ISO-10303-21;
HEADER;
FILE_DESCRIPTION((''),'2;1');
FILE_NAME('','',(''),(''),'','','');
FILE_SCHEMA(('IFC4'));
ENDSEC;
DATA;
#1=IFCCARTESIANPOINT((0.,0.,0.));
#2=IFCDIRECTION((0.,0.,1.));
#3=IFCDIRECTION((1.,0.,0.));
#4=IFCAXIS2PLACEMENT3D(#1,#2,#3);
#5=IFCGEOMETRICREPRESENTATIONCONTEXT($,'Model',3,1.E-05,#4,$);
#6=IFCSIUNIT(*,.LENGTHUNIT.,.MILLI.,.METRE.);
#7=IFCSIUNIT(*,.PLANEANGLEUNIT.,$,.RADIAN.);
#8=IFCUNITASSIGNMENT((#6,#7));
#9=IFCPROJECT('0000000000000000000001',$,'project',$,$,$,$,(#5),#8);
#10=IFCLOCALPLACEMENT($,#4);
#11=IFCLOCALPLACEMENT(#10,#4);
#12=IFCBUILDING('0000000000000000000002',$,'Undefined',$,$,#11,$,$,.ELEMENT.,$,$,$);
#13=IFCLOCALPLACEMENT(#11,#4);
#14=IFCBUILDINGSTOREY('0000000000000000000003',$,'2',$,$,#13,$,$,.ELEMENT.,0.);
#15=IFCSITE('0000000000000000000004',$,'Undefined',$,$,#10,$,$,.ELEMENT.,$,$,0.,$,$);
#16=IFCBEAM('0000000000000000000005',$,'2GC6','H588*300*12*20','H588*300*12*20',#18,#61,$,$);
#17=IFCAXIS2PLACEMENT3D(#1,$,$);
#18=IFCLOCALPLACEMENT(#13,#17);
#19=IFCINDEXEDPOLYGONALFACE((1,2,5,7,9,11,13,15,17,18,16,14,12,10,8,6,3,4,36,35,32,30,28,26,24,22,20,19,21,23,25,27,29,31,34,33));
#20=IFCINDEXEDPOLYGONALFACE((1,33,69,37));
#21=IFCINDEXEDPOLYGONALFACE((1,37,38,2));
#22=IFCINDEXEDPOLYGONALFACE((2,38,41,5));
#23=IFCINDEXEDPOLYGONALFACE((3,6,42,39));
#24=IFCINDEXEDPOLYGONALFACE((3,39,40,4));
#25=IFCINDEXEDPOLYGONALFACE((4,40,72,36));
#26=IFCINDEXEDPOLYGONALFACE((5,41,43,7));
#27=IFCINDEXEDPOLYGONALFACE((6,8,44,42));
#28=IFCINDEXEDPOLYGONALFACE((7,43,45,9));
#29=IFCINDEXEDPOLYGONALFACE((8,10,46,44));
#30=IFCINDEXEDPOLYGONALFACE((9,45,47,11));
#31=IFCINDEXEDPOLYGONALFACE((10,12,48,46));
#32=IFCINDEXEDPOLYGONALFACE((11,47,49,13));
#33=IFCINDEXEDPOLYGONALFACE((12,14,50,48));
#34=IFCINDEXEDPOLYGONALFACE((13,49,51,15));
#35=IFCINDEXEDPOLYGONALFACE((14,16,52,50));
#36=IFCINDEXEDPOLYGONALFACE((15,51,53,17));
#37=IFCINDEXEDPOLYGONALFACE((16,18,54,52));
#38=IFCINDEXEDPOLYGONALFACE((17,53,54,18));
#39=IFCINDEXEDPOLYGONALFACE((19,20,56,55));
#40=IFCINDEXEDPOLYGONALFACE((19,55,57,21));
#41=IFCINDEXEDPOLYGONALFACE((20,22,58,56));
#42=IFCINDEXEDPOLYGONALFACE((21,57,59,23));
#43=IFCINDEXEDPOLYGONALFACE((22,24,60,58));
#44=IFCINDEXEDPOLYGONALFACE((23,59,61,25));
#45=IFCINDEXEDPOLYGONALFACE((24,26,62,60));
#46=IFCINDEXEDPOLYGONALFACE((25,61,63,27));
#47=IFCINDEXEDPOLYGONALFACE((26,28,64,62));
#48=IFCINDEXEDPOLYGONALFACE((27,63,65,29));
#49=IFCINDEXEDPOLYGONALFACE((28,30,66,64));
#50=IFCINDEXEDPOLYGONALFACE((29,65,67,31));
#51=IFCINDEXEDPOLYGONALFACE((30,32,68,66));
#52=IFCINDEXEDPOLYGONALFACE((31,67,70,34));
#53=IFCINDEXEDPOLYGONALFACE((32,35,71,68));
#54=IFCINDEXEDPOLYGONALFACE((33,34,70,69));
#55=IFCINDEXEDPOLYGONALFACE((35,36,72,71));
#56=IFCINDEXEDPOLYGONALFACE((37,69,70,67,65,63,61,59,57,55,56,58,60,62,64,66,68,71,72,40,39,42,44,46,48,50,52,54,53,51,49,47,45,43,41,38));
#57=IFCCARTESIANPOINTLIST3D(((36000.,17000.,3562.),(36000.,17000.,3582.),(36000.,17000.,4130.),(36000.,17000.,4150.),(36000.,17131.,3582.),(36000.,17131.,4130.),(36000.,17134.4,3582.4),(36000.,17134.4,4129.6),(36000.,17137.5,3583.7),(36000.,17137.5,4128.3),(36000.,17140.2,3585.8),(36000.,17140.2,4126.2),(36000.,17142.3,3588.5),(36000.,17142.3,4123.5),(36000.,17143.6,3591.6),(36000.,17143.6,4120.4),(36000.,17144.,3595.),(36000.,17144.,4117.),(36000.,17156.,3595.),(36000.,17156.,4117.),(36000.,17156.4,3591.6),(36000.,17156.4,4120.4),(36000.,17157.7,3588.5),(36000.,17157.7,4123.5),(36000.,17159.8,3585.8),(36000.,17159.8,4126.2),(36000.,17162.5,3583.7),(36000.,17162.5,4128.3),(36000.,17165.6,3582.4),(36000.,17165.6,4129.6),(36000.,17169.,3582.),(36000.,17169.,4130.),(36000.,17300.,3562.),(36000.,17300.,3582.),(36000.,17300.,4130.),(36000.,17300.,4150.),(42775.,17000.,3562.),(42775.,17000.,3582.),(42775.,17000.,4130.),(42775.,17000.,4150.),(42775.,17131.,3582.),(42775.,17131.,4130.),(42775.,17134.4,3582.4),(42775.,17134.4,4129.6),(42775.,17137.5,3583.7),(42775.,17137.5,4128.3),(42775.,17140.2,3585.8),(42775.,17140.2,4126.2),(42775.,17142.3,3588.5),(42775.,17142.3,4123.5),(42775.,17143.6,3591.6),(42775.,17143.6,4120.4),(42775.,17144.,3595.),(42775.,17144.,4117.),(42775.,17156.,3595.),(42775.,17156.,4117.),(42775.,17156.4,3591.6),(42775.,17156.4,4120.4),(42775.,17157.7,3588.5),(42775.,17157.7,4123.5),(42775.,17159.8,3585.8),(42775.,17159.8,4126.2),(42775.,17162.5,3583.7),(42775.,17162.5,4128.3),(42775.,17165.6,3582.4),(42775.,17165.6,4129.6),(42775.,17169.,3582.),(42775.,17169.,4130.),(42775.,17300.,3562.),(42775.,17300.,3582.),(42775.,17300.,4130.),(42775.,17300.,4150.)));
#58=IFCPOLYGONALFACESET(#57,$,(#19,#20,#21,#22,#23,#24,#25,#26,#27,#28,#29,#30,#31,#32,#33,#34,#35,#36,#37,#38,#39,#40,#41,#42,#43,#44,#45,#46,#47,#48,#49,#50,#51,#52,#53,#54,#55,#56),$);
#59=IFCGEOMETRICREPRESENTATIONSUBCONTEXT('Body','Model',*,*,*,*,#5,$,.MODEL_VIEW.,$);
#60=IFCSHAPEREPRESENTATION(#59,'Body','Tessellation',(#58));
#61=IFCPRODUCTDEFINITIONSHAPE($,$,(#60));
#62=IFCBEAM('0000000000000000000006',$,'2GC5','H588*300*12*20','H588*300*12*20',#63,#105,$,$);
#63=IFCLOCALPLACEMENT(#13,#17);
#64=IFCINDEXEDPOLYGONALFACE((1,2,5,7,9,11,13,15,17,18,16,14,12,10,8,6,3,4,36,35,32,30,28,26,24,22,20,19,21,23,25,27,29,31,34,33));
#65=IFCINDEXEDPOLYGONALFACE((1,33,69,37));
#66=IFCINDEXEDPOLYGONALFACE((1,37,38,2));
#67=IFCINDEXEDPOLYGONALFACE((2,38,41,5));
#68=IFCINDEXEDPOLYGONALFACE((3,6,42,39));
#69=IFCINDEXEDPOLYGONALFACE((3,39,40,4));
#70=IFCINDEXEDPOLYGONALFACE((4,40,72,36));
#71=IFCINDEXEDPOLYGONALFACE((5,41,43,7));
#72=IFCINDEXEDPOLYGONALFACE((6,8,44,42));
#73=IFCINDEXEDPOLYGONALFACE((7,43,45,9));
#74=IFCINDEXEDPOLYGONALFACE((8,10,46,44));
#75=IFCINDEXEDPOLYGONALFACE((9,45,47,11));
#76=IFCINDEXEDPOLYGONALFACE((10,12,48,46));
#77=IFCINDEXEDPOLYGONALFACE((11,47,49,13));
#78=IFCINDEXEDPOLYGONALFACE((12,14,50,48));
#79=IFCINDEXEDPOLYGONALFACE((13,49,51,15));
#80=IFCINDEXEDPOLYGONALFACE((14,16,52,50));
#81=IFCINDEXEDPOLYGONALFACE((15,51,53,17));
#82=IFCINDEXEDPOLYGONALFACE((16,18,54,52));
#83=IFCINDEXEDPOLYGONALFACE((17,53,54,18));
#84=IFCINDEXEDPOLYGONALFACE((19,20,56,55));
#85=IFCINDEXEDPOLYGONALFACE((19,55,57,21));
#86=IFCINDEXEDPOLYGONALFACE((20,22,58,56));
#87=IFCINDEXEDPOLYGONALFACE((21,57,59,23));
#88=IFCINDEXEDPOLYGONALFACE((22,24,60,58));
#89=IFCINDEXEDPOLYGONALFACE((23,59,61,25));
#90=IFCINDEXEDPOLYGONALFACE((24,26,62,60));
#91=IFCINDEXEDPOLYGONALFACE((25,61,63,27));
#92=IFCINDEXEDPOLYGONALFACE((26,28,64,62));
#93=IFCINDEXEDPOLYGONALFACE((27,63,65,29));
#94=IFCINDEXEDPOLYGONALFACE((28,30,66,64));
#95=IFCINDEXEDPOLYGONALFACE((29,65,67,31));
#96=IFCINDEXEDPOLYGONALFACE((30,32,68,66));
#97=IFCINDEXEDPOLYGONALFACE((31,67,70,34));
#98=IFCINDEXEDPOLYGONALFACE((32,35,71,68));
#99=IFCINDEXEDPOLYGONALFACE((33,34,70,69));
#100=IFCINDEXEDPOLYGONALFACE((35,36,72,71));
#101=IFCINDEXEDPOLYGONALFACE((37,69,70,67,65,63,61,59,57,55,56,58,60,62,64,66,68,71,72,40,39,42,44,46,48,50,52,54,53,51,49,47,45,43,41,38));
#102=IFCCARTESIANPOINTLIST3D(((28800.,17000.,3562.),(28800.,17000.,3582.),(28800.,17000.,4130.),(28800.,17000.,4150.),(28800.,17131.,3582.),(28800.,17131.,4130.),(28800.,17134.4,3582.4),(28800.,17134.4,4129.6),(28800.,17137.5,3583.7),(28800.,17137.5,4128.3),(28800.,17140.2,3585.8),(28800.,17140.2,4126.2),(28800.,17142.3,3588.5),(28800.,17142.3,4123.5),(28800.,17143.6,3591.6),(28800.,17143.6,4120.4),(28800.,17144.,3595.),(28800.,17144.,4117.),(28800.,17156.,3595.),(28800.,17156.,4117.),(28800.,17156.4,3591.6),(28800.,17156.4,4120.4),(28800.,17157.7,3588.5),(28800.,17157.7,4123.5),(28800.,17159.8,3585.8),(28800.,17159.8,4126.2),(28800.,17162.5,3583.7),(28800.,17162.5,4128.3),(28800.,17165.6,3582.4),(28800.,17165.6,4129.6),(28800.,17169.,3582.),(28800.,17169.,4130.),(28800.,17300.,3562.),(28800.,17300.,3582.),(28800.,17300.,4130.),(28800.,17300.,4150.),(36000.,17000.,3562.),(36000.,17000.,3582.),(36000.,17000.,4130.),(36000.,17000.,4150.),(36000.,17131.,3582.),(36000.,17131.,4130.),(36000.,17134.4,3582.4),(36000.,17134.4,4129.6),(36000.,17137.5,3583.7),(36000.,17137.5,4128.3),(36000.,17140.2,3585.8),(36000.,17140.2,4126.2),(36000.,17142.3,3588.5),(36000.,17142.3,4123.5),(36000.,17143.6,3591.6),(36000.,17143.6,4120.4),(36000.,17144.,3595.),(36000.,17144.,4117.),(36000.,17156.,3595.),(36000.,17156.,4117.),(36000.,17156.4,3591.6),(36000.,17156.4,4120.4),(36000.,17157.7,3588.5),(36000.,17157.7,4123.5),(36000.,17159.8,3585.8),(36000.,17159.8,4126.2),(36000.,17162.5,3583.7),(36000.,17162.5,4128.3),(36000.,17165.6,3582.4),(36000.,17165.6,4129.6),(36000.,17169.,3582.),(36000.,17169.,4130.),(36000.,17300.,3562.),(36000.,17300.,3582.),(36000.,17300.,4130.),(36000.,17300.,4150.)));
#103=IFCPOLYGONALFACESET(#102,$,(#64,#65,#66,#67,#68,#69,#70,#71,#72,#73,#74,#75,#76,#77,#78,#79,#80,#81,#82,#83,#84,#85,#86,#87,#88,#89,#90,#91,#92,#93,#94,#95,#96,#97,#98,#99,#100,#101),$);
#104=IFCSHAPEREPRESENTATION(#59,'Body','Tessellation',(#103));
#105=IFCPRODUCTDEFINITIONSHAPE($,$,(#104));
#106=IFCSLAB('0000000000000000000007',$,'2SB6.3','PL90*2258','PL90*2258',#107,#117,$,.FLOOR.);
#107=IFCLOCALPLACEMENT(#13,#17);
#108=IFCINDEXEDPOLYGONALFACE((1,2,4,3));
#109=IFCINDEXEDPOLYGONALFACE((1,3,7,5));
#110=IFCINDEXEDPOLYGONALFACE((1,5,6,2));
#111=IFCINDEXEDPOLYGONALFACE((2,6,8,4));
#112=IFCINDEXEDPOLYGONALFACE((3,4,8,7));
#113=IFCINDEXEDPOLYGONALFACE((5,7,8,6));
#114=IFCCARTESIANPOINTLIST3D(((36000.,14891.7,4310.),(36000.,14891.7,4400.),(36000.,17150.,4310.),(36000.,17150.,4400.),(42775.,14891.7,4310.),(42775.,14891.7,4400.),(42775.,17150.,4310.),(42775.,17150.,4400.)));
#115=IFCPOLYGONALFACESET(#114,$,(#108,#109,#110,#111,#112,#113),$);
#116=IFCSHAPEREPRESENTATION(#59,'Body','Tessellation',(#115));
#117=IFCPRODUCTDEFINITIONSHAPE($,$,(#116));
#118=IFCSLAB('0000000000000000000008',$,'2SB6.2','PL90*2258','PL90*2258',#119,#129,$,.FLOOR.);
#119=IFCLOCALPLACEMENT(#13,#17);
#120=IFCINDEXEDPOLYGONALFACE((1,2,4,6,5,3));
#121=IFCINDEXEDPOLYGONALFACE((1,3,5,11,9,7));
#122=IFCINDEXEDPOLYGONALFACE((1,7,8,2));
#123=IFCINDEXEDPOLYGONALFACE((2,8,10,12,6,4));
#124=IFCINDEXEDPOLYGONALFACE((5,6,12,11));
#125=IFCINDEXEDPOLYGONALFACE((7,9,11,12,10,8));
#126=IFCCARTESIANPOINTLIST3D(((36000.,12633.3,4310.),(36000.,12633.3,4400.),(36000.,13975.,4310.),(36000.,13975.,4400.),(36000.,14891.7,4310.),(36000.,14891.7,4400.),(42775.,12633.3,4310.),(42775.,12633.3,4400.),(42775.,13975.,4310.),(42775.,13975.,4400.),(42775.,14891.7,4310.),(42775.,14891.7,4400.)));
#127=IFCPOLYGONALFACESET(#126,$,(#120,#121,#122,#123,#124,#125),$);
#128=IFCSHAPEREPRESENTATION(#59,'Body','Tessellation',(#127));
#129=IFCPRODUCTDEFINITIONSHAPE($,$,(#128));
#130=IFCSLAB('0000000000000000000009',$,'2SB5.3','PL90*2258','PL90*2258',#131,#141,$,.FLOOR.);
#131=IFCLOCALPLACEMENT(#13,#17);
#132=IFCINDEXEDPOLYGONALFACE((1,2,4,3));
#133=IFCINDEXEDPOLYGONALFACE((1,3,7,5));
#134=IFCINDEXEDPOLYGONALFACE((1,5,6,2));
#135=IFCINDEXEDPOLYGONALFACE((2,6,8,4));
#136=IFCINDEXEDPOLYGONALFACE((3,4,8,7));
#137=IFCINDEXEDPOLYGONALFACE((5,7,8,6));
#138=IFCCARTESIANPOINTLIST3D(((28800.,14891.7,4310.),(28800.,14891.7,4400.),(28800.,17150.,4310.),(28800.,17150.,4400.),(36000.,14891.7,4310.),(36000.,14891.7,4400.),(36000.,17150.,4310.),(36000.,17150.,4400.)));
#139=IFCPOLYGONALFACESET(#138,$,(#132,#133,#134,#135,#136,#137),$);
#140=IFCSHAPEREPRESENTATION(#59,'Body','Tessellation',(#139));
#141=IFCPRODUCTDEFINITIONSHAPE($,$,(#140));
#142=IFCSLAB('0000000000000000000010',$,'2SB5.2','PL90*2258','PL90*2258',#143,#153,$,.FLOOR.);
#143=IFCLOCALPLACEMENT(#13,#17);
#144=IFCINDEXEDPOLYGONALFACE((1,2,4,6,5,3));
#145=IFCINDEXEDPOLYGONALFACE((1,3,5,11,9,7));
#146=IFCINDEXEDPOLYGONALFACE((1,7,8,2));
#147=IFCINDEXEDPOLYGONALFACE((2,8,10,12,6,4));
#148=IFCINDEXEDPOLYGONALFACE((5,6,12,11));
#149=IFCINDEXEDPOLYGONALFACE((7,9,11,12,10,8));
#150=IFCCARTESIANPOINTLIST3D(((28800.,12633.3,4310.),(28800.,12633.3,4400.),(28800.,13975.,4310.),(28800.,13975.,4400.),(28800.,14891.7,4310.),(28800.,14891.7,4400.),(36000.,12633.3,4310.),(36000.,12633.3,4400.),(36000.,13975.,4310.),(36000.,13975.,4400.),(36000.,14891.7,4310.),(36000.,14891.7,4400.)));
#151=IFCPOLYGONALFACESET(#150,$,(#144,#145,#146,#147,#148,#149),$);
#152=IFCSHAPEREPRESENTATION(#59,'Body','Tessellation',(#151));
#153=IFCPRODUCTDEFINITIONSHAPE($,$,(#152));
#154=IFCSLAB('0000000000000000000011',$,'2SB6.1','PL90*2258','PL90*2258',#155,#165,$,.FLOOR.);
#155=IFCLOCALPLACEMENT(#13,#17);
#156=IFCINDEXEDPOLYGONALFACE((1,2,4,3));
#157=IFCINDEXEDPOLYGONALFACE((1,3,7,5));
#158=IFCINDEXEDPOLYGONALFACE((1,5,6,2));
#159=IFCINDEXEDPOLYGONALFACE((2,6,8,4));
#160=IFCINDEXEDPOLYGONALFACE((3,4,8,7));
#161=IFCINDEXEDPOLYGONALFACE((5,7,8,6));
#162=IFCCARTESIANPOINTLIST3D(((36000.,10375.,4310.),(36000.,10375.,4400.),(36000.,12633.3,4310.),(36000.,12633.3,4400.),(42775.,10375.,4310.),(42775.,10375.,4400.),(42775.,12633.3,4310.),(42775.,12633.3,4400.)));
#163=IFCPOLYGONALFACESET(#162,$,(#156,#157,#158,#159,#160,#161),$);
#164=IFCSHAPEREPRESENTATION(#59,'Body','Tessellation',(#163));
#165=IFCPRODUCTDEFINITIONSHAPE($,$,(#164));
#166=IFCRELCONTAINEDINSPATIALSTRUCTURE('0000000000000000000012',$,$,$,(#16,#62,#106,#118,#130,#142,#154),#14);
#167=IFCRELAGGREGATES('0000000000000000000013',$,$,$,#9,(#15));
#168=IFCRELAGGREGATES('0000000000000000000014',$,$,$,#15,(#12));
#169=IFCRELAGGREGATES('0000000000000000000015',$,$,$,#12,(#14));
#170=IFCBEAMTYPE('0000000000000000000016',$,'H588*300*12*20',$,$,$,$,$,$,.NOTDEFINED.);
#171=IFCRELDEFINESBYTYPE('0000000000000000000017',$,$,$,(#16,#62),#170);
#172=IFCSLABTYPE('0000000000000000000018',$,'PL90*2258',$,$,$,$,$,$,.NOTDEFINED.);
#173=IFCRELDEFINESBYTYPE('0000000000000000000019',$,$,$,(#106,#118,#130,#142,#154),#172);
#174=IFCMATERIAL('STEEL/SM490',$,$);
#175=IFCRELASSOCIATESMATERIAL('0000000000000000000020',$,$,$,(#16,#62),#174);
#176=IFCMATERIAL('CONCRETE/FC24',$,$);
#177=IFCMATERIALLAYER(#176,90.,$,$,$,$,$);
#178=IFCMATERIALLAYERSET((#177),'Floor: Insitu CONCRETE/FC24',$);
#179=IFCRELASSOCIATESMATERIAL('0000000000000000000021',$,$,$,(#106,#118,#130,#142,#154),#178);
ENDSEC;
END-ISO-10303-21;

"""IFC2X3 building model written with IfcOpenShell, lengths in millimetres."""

from ifc_helpers import new_model, si_unit, frame, origin_with_axes, origin_2d_with_axis, place, context, subcontext, project, spatial, polyline, i_section, outline, extrude, material, layer, layer_set, layer_usage, type_object, element, save


model = new_model("IFC2X3")

# Units and contexts
model_context = context("Model", 3, precision=1e-05, world=origin_with_axes())
body_context = subcontext(model_context, "Body", "Model", "MODEL_VIEW")
ifc_project = project(units=[si_unit("LENGTHUNIT", "METRE", prefix="MILLI"), si_unit("PLANEANGLEUNIT", "RADIAN")], contexts=[model_context])

# Site, building, storey
site_placement = place(None, origin_with_axes())
site = spatial("IfcSite", under=ifc_project, at=site_placement, Name="Undefined", CompositionType="ELEMENT", RefElevation=0.0)
building_placement = place(site_placement, origin_with_axes())
building = spatial("IfcBuilding", under=site, at=building_placement, Name="Undefined", CompositionType="ELEMENT")
storey_placement = place(building_placement, origin_with_axes())
storey = spatial("IfcBuildingStorey", under=building, at=storey_placement, Name="2", CompositionType="ELEMENT", Elevation=0.0)

# Beams
ifc_material_1 = material(Name="STEEL/SM490")
beam_type_1 = type_object("IfcBeamType", Name="H588*300*12*20", PredefinedType="NOTDEFINED")
beam_1_placement = place(storey_placement, frame((36000.0, 17150.0, 3856.0), z_axis=(0.0, 0.0, 1.0), x_axis=(1.0, 0.0, 0.0)))
element("IfcBeam", 1, at=beam_1_placement, inside=storey, type_object=beam_type_1, material=ifc_material_1, Name="2GC6", Description="H588*300*12*20", ObjectType="H588*300*12*20", context=body_context, shape_type="SweptSolid", body=[
    extrude(i_section(OverallWidth=300.0, OverallDepth=588.0, WebThickness=12.0, FlangeThickness=20.0, FilletRadius=13.0, at=origin_2d_with_axis()), frame((6775.0, 0.0, 0.0), z_axis=(-1.0, 0.0, 0.0), x_axis=(0.0, -1.0, 0.0)), (0.0, 0.0, 1.0), 6775.0),
])
beam_2_placement = place(storey_placement, frame((28800.0, 17150.0, 3856.0), z_axis=(0.0, 0.0, 1.0), x_axis=(1.0, 0.0, 0.0)))
element("IfcBeam", 2, at=beam_2_placement, inside=storey, type_object=beam_type_1, material=ifc_material_1, Name="2GC5", Description="H588*300*12*20", ObjectType="H588*300*12*20", context=body_context, shape_type="SweptSolid", body=[
    extrude(i_section(OverallWidth=300.0, OverallDepth=588.0, WebThickness=12.0, FlangeThickness=20.0, FilletRadius=13.0, at=origin_2d_with_axis()), frame((7200.0, 0.0, 0.0), z_axis=(-1.0, 0.0, 0.0), x_axis=(0.0, -1.0, 0.0)), (0.0, 0.0, 1.0), 7200.0),
])

# Slabs
ifc_material_2 = material(Name="CONCRETE/FC24")
ifc_layer = layer(ifc_material_2, 90.0)
ifc_layer_set = layer_set([ifc_layer], Name="Floor: Insitu CONCRETE/FC24")
ifc_layer_usage_1 = layer_usage(ifc_layer_set, "AXIS3", "POSITIVE", -45.0)
slab_type = type_object("IfcSlabType", Name="PL90*2258", PredefinedType="NOTDEFINED")
slab_1_placement = place(storey_placement, frame((36000.0, 14891.7, 4355.0), z_axis=(0.0, 0.0, 1.0), x_axis=(1.0, 0.0, 0.0)))
element("IfcSlab", 3, at=slab_1_placement, inside=storey, type_object=slab_type, material=ifc_layer_usage_1, Name="2SB6.3", Description="PL90*2258", ObjectType="PL90*2258", PredefinedType="FLOOR", context=body_context, shape_type="SweptSolid", body=[
    extrude(outline(polyline([(0.0, 0.0), (6775.0, 0.0), (6775.0, 2258.3), (0.0, 2258.3), (0.0, 0.0)])), frame((0.0, 0.0, -45.0), z_axis=(0.0, 0.0, 1.0), x_axis=(1.0, 0.0, 0.0)), (0.0, 0.0, 1.0), 90.0),
])
ifc_layer_usage_2 = layer_usage(ifc_layer_set, "AXIS3", "POSITIVE", -45.0)
slab_2_placement = place(storey_placement, frame((36000.0, 12633.3, 4355.0), z_axis=(0.0, 0.0, 1.0), x_axis=(1.0, 0.0, 0.0)))
element("IfcSlab", 4, at=slab_2_placement, inside=storey, type_object=slab_type, material=ifc_layer_usage_2, Name="2SB6.2", Description="PL90*2258", ObjectType="PL90*2258", PredefinedType="FLOOR", context=body_context, shape_type="SweptSolid", body=[
    extrude(outline(polyline([(0.0, 0.0), (6775.0, 0.0), (6775.0, 1341.7), (6775.0, 2258.4), (0.0, 2258.4), (0.0, 1341.7), (0.0, 0.0)])), frame((0.0, 0.0, -45.0), z_axis=(0.0, 0.0, 1.0), x_axis=(1.0, 0.0, 0.0)), (0.0, 0.0, 1.0), 90.0),
])
ifc_layer_usage_3 = layer_usage(ifc_layer_set, "AXIS3", "POSITIVE", -45.0)
slab_3_placement = place(storey_placement, frame((28800.0, 14891.7, 4355.0), z_axis=(0.0, 0.0, 1.0), x_axis=(1.0, 0.0, 0.0)))
element("IfcSlab", 5, at=slab_3_placement, inside=storey, type_object=slab_type, material=ifc_layer_usage_3, Name="2SB5.3", Description="PL90*2258", ObjectType="PL90*2258", PredefinedType="FLOOR", context=body_context, shape_type="SweptSolid", body=[
    extrude(outline(polyline([(0.0, 0.0), (7200.0, 0.0), (7200.0, 2258.3), (0.0, 2258.3), (0.0, 0.0)])), frame((0.0, 0.0, -45.0), z_axis=(0.0, 0.0, 1.0), x_axis=(1.0, 0.0, 0.0)), (0.0, 0.0, 1.0), 90.0),
])
ifc_layer_usage_4 = layer_usage(ifc_layer_set, "AXIS3", "POSITIVE", -45.0)
slab_4_placement = place(storey_placement, frame((28800.0, 12633.3, 4355.0), z_axis=(0.0, 0.0, 1.0), x_axis=(1.0, 0.0, 0.0)))
element("IfcSlab", 6, at=slab_4_placement, inside=storey, type_object=slab_type, material=ifc_layer_usage_4, Name="2SB5.2", Description="PL90*2258", ObjectType="PL90*2258", PredefinedType="FLOOR", context=body_context, shape_type="SweptSolid", body=[
    extrude(outline(polyline([(0.0, 0.0), (7200.0, 0.0), (7200.0, 1341.7), (7200.0, 2258.4), (0.0, 2258.4), (0.0, 1341.7), (0.0, 0.0)])), frame((0.0, 0.0, -45.0), z_axis=(0.0, 0.0, 1.0), x_axis=(1.0, 0.0, 0.0)), (0.0, 0.0, 1.0), 90.0),
])
ifc_layer_usage_5 = layer_usage(ifc_layer_set, "AXIS3", "POSITIVE", -45.0)
slab_5_placement = place(storey_placement, frame((36000.0, 10375.0, 4355.0), z_axis=(0.0, 0.0, 1.0), x_axis=(1.0, 0.0, 0.0)))
element("IfcSlab", 7, at=slab_5_placement, inside=storey, type_object=slab_type, material=ifc_layer_usage_5, Name="2SB6.1", Description="PL90*2258", ObjectType="PL90*2258", PredefinedType="FLOOR", context=body_context, shape_type="SweptSolid", body=[
    extrude(outline(polyline([(0.0, 0.0), (6775.0, 0.0), (6775.0, 2258.3), (0.0, 2258.3), (0.0, 0.0)])), frame((0.0, 0.0, -45.0), z_axis=(0.0, 0.0, 1.0), x_axis=(1.0, 0.0, 0.0)), (0.0, 0.0, 1.0), 90.0),
])

save(model, "model.ifc")
